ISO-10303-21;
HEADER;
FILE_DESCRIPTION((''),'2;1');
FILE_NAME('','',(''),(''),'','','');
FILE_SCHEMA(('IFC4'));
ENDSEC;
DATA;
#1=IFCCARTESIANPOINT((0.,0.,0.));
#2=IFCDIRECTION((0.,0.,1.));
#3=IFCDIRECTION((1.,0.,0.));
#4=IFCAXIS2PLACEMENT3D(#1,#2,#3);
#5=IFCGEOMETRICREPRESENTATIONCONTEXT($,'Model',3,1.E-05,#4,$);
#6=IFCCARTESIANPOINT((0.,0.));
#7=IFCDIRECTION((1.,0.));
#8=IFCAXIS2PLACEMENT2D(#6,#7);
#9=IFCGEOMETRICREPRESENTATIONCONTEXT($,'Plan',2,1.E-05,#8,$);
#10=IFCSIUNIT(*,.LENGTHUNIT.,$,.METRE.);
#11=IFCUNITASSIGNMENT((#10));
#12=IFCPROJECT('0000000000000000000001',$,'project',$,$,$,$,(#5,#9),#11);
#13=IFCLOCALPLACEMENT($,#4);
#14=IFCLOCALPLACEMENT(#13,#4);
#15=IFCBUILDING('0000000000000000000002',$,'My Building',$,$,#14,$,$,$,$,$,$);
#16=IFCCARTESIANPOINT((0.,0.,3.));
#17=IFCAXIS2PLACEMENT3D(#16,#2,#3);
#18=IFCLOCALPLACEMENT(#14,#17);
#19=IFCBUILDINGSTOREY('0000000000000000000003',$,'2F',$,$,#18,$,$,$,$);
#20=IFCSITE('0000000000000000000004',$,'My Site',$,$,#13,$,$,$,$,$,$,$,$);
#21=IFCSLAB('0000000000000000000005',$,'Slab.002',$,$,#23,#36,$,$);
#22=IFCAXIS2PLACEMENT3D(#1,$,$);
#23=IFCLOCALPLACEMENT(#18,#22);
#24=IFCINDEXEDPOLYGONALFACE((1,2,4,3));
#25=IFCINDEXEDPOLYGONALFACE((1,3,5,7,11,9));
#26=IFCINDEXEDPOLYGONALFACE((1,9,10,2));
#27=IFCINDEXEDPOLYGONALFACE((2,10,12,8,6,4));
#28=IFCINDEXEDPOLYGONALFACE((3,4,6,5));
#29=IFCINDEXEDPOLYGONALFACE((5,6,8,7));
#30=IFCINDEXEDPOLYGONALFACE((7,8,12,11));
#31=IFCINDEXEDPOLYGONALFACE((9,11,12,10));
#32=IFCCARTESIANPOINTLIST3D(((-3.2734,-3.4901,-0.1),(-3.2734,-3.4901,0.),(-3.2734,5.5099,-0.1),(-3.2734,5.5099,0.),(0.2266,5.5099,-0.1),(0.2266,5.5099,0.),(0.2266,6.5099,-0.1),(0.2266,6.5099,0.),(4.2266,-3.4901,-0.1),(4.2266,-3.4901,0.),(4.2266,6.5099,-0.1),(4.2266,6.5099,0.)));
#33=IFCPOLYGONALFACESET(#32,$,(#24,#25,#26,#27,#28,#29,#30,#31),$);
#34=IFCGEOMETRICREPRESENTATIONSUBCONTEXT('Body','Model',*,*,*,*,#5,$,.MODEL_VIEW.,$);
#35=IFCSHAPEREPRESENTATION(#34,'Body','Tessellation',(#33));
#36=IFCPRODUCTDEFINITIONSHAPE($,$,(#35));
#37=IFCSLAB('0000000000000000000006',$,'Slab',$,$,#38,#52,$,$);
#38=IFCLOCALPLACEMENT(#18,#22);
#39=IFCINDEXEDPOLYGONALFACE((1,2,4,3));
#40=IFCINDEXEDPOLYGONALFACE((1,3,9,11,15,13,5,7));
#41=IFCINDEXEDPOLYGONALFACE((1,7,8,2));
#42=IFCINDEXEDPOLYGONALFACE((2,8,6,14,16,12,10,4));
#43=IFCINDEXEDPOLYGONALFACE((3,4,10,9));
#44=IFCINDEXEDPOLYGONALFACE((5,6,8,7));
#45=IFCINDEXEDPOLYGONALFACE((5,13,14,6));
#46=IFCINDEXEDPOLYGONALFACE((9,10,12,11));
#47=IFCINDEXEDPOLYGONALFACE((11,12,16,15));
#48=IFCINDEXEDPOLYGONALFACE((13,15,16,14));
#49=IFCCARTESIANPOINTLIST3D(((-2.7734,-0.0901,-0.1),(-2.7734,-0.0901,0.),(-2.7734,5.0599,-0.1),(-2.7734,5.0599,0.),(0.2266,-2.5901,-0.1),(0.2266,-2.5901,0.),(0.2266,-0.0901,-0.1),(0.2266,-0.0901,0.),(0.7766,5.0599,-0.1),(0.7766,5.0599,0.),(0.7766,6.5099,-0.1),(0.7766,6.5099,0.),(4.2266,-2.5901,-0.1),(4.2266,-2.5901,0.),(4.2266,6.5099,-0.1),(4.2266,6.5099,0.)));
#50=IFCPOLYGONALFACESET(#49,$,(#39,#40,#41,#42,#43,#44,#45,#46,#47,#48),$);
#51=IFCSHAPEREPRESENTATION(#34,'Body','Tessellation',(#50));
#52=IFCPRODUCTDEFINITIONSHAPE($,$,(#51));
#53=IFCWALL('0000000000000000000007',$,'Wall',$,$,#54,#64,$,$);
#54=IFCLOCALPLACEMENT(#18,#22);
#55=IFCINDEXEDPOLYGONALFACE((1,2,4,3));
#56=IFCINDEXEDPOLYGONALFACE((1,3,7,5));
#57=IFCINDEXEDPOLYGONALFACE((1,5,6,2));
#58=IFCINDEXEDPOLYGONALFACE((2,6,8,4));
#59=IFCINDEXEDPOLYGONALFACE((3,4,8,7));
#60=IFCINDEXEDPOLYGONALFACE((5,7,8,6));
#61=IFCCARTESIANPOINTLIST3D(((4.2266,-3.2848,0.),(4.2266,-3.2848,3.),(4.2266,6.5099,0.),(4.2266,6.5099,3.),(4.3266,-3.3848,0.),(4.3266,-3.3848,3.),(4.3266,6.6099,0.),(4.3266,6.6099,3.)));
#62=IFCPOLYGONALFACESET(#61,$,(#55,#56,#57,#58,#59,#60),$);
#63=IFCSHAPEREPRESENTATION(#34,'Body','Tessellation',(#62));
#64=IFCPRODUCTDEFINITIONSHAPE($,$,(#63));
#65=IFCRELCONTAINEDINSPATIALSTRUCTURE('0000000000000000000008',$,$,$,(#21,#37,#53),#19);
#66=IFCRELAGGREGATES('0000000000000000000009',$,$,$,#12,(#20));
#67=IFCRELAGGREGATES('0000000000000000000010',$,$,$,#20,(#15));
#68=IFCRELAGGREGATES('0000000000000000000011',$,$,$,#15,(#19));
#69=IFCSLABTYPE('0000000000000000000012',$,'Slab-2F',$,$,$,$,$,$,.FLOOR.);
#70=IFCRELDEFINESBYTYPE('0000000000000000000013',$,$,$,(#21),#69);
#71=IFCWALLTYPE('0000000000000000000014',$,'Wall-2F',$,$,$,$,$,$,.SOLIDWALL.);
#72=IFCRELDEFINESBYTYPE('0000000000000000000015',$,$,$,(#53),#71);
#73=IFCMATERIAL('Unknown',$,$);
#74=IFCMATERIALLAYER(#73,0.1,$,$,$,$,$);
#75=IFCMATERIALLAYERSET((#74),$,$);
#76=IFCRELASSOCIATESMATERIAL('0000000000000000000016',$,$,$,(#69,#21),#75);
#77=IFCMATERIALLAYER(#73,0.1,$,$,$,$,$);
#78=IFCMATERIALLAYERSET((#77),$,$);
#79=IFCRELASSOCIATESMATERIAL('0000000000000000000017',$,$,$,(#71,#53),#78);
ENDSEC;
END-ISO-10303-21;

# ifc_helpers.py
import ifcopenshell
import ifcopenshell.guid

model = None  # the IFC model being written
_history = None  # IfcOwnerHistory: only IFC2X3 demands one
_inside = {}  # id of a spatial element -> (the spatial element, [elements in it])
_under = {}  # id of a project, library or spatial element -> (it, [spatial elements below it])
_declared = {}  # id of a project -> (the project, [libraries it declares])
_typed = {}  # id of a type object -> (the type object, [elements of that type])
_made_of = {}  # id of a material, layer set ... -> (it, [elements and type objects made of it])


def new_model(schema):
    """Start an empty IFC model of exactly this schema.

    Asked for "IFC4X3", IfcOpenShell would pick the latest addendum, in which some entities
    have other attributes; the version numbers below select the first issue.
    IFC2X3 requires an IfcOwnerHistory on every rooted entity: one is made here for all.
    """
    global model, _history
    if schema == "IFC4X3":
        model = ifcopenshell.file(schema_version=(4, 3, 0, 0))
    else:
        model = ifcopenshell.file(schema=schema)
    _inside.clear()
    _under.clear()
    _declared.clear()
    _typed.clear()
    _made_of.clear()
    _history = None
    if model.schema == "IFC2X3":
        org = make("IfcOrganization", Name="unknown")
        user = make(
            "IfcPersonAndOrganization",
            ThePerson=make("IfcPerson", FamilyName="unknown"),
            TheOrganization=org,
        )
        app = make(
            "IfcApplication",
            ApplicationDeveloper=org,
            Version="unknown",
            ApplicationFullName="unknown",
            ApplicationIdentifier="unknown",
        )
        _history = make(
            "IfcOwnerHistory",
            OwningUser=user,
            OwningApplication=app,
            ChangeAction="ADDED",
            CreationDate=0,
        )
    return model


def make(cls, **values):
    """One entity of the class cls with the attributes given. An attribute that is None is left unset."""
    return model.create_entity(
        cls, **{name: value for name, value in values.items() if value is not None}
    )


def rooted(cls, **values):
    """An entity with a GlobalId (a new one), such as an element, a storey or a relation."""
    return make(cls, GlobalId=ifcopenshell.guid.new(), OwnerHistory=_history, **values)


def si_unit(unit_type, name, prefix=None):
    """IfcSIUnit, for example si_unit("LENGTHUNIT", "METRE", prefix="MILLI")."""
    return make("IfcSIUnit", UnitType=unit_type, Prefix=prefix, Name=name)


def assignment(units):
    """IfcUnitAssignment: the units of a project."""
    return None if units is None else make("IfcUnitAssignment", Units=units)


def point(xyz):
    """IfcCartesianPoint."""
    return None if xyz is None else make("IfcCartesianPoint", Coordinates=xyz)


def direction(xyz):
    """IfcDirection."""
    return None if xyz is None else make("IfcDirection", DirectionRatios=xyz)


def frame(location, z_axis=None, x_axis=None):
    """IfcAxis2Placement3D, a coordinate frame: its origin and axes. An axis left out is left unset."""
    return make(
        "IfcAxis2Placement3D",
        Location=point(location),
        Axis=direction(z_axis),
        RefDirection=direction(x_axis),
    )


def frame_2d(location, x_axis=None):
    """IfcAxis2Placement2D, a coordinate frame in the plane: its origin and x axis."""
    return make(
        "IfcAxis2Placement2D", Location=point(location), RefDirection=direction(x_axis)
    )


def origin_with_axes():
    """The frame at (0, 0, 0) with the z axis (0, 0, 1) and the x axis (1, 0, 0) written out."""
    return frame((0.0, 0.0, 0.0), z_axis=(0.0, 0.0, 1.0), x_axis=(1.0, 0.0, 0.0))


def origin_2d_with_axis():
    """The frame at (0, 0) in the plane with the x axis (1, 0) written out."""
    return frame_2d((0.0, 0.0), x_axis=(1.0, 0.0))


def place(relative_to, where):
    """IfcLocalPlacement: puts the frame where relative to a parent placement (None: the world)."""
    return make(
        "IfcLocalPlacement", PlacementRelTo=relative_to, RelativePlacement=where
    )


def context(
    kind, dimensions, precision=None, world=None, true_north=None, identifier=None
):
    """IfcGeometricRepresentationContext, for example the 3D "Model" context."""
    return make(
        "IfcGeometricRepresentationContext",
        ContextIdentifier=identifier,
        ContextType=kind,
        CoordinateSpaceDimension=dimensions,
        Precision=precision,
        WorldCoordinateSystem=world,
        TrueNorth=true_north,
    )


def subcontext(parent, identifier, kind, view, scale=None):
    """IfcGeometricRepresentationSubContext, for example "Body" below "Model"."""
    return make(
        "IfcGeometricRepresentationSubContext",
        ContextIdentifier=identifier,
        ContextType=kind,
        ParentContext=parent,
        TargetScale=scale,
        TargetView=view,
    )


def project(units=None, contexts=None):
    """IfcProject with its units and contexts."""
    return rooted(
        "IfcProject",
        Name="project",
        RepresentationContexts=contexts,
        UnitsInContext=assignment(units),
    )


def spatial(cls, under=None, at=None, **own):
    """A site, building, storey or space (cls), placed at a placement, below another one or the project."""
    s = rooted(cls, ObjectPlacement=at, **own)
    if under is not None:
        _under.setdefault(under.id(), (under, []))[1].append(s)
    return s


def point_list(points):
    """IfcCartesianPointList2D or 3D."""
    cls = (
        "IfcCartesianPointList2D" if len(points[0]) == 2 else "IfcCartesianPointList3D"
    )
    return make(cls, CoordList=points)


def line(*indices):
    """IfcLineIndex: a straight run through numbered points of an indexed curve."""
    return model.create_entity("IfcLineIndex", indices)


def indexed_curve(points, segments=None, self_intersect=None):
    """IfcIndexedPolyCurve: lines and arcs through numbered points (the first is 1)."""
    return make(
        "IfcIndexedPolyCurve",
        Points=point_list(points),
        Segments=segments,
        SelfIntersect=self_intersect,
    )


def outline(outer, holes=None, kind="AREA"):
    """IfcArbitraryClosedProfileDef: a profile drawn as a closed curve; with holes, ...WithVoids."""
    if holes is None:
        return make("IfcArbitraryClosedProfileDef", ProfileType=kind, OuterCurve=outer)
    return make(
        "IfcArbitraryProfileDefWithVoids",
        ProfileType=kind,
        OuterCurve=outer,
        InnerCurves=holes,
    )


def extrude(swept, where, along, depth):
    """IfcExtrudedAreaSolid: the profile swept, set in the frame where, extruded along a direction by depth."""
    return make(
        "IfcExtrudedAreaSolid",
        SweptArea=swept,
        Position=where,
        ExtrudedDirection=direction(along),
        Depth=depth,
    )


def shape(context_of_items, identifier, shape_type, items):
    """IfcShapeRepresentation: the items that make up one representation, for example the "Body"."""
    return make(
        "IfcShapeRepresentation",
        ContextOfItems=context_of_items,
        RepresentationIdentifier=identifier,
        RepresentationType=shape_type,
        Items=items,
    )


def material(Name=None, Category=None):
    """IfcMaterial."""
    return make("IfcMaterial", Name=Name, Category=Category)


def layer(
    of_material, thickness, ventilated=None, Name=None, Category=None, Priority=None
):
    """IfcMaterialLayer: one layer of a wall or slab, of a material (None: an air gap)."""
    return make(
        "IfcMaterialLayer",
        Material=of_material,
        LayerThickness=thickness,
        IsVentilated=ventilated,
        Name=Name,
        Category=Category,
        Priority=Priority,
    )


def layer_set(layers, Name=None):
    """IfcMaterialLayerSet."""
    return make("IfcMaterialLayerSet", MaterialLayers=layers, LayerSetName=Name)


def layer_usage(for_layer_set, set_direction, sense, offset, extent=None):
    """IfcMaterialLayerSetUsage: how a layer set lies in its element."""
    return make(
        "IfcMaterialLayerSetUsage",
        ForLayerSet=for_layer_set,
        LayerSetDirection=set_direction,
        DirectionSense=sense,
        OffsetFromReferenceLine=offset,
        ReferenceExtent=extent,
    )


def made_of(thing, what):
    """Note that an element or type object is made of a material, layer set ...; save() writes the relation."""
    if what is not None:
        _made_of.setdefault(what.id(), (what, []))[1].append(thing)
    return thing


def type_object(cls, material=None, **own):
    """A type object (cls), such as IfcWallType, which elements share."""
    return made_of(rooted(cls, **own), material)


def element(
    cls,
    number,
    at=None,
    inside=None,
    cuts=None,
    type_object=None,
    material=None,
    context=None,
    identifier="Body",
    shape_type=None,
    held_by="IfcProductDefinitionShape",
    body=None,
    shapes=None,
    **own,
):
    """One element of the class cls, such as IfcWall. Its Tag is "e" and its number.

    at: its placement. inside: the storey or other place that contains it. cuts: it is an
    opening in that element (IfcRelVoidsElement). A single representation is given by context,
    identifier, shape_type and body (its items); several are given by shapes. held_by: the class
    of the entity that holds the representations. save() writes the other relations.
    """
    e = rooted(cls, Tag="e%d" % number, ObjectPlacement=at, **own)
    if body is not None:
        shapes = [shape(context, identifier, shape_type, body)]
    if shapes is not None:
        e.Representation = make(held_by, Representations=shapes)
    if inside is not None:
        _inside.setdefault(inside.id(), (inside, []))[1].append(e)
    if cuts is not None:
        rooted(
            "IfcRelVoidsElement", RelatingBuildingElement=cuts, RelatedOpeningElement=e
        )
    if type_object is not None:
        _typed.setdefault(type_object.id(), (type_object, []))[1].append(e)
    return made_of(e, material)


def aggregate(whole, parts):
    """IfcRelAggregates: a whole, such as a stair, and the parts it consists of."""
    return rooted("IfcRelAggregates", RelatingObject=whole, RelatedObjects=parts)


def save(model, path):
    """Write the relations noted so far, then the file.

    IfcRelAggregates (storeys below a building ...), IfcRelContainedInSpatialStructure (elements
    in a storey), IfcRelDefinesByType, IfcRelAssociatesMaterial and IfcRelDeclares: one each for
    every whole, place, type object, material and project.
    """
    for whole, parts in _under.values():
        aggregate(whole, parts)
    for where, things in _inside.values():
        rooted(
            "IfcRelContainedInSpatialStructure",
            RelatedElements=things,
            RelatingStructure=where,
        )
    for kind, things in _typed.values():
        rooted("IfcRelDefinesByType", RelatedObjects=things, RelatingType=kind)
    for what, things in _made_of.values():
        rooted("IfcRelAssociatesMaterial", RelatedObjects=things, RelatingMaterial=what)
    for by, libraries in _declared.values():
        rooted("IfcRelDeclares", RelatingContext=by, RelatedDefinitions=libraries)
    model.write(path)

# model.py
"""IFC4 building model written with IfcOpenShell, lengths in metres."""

from ifc_helpers import new_model, si_unit, frame, origin_with_axes, origin_2d_with_axis, place, context, subcontext, project, spatial, line, indexed_curve, outline, extrude, material, layer, layer_set, layer_usage, type_object, element, save


model = new_model("IFC4")

# Units and contexts
model_context = context("Model", 3, precision=1e-05, world=origin_with_axes())
plan_context = context("Plan", 2, precision=1e-05, world=origin_2d_with_axis())
body_context_1 = subcontext(model_context, "Body", "Model", "MODEL_VIEW")
ifc_project = project(units=[si_unit("LENGTHUNIT", "METRE")], contexts=[model_context, plan_context])

# Site, building, storey
site_placement = place(None, origin_with_axes())
site = spatial("IfcSite", under=ifc_project, at=site_placement, Name="My Site")
building_placement = place(site_placement, origin_with_axes())
building = spatial("IfcBuilding", under=site, at=building_placement, Name="My Building")
storey_placement = place(building_placement, frame((0.0, 0.0, 3.0), z_axis=(0.0, 0.0, 1.0), x_axis=(1.0, 0.0, 0.0)))
storey = spatial("IfcBuildingStorey", under=building, at=storey_placement, Name="2F")

# Slabs
ifc_material = material(Name="Unknown")
ifc_layer_1 = layer(ifc_material, 0.1)
ifc_layer_set_1 = layer_set([ifc_layer_1])
ifc_layer_usage_1 = layer_usage(ifc_layer_set_1, "AXIS3", "POSITIVE", -0.1)
slab_type = type_object("IfcSlabType", Name="Slab-2F", PredefinedType="FLOOR", material=ifc_layer_set_1)
slab_1_placement = place(storey_placement, frame((4.2266, 6.5099, 0.0), z_axis=(0.0, 0.0, 1.0), x_axis=(1.0, 0.0, 0.0)))
element("IfcSlab", 1, at=slab_1_placement, inside=storey, type_object=slab_type, material=ifc_layer_usage_1, Name="Slab.002", context=body_context_1, shape_type="SweptSolid", body=[
    extrude(outline(indexed_curve([(0.0, 0.0), (0.0, -10.0), (-7.5, -10.0), (-7.5, -1.0), (-4.0, -1.0), (-4.0, 0.0), (0.0, 0.0)])), frame((0.0, 0.0, -0.1), z_axis=(0.0, 0.0, 1.0), x_axis=(1.0, 0.0, 0.0)), (0.0, 0.0, 1.0), 0.1),
])
slab_2_placement = place(storey_placement, frame((0.7766, 6.5099, 0.0), z_axis=(0.0, 0.0, 1.0), x_axis=(1.0, 0.0, 0.0)))
element("IfcSlab", 2, at=slab_2_placement, inside=storey, Name="Slab", context=body_context_1, shape_type="SweptSolid", body=[
    extrude(outline(indexed_curve([(0.0, 0.0), (3.45, 0.0), (3.45, -9.1), (-0.55, -9.1), (-0.55, -6.6), (-3.55, -6.6), (-3.55, -1.45), (0.0, -1.45), (0.0, 0.0)])), frame((0.0, 0.0, -0.1), z_axis=(0.0, 0.0, 1.0), x_axis=(1.0, 0.0, 0.0)), (0.0, 0.0, 1.0), 0.1),
])

# Wall
ifc_layer_2 = layer(ifc_material, 0.1)
ifc_layer_set_2 = layer_set([ifc_layer_2])
ifc_layer_usage_2 = layer_usage(ifc_layer_set_2, "AXIS2", "POSITIVE", 0.0)
wall_type = type_object("IfcWallType", Name="Wall-2F", PredefinedType="SOLIDWALL", material=ifc_layer_set_2)
wall_1_placement = place(storey_placement, frame((4.2266, 6.5099, 0.0), z_axis=(0.0, 0.0, 1.0), x_axis=(0.0, -1.0, 0.0)))
element("IfcWall", 3, at=wall_1_placement, inside=storey, type_object=wall_type, material=ifc_layer_usage_2, Name="Wall", context=body_context_1, shape_type="SweptSolid", body=[
    extrude(outline(indexed_curve([(0.0, 0.0), (-0.1, 0.1), (9.8946, 0.1), (9.7946, 0.0)], segments=[line(1, 2, 3, 4, 1)])), origin_with_axes(), (0.0, 0.0, 1.0), 3.0),
])

save(model, "model.ifc")
